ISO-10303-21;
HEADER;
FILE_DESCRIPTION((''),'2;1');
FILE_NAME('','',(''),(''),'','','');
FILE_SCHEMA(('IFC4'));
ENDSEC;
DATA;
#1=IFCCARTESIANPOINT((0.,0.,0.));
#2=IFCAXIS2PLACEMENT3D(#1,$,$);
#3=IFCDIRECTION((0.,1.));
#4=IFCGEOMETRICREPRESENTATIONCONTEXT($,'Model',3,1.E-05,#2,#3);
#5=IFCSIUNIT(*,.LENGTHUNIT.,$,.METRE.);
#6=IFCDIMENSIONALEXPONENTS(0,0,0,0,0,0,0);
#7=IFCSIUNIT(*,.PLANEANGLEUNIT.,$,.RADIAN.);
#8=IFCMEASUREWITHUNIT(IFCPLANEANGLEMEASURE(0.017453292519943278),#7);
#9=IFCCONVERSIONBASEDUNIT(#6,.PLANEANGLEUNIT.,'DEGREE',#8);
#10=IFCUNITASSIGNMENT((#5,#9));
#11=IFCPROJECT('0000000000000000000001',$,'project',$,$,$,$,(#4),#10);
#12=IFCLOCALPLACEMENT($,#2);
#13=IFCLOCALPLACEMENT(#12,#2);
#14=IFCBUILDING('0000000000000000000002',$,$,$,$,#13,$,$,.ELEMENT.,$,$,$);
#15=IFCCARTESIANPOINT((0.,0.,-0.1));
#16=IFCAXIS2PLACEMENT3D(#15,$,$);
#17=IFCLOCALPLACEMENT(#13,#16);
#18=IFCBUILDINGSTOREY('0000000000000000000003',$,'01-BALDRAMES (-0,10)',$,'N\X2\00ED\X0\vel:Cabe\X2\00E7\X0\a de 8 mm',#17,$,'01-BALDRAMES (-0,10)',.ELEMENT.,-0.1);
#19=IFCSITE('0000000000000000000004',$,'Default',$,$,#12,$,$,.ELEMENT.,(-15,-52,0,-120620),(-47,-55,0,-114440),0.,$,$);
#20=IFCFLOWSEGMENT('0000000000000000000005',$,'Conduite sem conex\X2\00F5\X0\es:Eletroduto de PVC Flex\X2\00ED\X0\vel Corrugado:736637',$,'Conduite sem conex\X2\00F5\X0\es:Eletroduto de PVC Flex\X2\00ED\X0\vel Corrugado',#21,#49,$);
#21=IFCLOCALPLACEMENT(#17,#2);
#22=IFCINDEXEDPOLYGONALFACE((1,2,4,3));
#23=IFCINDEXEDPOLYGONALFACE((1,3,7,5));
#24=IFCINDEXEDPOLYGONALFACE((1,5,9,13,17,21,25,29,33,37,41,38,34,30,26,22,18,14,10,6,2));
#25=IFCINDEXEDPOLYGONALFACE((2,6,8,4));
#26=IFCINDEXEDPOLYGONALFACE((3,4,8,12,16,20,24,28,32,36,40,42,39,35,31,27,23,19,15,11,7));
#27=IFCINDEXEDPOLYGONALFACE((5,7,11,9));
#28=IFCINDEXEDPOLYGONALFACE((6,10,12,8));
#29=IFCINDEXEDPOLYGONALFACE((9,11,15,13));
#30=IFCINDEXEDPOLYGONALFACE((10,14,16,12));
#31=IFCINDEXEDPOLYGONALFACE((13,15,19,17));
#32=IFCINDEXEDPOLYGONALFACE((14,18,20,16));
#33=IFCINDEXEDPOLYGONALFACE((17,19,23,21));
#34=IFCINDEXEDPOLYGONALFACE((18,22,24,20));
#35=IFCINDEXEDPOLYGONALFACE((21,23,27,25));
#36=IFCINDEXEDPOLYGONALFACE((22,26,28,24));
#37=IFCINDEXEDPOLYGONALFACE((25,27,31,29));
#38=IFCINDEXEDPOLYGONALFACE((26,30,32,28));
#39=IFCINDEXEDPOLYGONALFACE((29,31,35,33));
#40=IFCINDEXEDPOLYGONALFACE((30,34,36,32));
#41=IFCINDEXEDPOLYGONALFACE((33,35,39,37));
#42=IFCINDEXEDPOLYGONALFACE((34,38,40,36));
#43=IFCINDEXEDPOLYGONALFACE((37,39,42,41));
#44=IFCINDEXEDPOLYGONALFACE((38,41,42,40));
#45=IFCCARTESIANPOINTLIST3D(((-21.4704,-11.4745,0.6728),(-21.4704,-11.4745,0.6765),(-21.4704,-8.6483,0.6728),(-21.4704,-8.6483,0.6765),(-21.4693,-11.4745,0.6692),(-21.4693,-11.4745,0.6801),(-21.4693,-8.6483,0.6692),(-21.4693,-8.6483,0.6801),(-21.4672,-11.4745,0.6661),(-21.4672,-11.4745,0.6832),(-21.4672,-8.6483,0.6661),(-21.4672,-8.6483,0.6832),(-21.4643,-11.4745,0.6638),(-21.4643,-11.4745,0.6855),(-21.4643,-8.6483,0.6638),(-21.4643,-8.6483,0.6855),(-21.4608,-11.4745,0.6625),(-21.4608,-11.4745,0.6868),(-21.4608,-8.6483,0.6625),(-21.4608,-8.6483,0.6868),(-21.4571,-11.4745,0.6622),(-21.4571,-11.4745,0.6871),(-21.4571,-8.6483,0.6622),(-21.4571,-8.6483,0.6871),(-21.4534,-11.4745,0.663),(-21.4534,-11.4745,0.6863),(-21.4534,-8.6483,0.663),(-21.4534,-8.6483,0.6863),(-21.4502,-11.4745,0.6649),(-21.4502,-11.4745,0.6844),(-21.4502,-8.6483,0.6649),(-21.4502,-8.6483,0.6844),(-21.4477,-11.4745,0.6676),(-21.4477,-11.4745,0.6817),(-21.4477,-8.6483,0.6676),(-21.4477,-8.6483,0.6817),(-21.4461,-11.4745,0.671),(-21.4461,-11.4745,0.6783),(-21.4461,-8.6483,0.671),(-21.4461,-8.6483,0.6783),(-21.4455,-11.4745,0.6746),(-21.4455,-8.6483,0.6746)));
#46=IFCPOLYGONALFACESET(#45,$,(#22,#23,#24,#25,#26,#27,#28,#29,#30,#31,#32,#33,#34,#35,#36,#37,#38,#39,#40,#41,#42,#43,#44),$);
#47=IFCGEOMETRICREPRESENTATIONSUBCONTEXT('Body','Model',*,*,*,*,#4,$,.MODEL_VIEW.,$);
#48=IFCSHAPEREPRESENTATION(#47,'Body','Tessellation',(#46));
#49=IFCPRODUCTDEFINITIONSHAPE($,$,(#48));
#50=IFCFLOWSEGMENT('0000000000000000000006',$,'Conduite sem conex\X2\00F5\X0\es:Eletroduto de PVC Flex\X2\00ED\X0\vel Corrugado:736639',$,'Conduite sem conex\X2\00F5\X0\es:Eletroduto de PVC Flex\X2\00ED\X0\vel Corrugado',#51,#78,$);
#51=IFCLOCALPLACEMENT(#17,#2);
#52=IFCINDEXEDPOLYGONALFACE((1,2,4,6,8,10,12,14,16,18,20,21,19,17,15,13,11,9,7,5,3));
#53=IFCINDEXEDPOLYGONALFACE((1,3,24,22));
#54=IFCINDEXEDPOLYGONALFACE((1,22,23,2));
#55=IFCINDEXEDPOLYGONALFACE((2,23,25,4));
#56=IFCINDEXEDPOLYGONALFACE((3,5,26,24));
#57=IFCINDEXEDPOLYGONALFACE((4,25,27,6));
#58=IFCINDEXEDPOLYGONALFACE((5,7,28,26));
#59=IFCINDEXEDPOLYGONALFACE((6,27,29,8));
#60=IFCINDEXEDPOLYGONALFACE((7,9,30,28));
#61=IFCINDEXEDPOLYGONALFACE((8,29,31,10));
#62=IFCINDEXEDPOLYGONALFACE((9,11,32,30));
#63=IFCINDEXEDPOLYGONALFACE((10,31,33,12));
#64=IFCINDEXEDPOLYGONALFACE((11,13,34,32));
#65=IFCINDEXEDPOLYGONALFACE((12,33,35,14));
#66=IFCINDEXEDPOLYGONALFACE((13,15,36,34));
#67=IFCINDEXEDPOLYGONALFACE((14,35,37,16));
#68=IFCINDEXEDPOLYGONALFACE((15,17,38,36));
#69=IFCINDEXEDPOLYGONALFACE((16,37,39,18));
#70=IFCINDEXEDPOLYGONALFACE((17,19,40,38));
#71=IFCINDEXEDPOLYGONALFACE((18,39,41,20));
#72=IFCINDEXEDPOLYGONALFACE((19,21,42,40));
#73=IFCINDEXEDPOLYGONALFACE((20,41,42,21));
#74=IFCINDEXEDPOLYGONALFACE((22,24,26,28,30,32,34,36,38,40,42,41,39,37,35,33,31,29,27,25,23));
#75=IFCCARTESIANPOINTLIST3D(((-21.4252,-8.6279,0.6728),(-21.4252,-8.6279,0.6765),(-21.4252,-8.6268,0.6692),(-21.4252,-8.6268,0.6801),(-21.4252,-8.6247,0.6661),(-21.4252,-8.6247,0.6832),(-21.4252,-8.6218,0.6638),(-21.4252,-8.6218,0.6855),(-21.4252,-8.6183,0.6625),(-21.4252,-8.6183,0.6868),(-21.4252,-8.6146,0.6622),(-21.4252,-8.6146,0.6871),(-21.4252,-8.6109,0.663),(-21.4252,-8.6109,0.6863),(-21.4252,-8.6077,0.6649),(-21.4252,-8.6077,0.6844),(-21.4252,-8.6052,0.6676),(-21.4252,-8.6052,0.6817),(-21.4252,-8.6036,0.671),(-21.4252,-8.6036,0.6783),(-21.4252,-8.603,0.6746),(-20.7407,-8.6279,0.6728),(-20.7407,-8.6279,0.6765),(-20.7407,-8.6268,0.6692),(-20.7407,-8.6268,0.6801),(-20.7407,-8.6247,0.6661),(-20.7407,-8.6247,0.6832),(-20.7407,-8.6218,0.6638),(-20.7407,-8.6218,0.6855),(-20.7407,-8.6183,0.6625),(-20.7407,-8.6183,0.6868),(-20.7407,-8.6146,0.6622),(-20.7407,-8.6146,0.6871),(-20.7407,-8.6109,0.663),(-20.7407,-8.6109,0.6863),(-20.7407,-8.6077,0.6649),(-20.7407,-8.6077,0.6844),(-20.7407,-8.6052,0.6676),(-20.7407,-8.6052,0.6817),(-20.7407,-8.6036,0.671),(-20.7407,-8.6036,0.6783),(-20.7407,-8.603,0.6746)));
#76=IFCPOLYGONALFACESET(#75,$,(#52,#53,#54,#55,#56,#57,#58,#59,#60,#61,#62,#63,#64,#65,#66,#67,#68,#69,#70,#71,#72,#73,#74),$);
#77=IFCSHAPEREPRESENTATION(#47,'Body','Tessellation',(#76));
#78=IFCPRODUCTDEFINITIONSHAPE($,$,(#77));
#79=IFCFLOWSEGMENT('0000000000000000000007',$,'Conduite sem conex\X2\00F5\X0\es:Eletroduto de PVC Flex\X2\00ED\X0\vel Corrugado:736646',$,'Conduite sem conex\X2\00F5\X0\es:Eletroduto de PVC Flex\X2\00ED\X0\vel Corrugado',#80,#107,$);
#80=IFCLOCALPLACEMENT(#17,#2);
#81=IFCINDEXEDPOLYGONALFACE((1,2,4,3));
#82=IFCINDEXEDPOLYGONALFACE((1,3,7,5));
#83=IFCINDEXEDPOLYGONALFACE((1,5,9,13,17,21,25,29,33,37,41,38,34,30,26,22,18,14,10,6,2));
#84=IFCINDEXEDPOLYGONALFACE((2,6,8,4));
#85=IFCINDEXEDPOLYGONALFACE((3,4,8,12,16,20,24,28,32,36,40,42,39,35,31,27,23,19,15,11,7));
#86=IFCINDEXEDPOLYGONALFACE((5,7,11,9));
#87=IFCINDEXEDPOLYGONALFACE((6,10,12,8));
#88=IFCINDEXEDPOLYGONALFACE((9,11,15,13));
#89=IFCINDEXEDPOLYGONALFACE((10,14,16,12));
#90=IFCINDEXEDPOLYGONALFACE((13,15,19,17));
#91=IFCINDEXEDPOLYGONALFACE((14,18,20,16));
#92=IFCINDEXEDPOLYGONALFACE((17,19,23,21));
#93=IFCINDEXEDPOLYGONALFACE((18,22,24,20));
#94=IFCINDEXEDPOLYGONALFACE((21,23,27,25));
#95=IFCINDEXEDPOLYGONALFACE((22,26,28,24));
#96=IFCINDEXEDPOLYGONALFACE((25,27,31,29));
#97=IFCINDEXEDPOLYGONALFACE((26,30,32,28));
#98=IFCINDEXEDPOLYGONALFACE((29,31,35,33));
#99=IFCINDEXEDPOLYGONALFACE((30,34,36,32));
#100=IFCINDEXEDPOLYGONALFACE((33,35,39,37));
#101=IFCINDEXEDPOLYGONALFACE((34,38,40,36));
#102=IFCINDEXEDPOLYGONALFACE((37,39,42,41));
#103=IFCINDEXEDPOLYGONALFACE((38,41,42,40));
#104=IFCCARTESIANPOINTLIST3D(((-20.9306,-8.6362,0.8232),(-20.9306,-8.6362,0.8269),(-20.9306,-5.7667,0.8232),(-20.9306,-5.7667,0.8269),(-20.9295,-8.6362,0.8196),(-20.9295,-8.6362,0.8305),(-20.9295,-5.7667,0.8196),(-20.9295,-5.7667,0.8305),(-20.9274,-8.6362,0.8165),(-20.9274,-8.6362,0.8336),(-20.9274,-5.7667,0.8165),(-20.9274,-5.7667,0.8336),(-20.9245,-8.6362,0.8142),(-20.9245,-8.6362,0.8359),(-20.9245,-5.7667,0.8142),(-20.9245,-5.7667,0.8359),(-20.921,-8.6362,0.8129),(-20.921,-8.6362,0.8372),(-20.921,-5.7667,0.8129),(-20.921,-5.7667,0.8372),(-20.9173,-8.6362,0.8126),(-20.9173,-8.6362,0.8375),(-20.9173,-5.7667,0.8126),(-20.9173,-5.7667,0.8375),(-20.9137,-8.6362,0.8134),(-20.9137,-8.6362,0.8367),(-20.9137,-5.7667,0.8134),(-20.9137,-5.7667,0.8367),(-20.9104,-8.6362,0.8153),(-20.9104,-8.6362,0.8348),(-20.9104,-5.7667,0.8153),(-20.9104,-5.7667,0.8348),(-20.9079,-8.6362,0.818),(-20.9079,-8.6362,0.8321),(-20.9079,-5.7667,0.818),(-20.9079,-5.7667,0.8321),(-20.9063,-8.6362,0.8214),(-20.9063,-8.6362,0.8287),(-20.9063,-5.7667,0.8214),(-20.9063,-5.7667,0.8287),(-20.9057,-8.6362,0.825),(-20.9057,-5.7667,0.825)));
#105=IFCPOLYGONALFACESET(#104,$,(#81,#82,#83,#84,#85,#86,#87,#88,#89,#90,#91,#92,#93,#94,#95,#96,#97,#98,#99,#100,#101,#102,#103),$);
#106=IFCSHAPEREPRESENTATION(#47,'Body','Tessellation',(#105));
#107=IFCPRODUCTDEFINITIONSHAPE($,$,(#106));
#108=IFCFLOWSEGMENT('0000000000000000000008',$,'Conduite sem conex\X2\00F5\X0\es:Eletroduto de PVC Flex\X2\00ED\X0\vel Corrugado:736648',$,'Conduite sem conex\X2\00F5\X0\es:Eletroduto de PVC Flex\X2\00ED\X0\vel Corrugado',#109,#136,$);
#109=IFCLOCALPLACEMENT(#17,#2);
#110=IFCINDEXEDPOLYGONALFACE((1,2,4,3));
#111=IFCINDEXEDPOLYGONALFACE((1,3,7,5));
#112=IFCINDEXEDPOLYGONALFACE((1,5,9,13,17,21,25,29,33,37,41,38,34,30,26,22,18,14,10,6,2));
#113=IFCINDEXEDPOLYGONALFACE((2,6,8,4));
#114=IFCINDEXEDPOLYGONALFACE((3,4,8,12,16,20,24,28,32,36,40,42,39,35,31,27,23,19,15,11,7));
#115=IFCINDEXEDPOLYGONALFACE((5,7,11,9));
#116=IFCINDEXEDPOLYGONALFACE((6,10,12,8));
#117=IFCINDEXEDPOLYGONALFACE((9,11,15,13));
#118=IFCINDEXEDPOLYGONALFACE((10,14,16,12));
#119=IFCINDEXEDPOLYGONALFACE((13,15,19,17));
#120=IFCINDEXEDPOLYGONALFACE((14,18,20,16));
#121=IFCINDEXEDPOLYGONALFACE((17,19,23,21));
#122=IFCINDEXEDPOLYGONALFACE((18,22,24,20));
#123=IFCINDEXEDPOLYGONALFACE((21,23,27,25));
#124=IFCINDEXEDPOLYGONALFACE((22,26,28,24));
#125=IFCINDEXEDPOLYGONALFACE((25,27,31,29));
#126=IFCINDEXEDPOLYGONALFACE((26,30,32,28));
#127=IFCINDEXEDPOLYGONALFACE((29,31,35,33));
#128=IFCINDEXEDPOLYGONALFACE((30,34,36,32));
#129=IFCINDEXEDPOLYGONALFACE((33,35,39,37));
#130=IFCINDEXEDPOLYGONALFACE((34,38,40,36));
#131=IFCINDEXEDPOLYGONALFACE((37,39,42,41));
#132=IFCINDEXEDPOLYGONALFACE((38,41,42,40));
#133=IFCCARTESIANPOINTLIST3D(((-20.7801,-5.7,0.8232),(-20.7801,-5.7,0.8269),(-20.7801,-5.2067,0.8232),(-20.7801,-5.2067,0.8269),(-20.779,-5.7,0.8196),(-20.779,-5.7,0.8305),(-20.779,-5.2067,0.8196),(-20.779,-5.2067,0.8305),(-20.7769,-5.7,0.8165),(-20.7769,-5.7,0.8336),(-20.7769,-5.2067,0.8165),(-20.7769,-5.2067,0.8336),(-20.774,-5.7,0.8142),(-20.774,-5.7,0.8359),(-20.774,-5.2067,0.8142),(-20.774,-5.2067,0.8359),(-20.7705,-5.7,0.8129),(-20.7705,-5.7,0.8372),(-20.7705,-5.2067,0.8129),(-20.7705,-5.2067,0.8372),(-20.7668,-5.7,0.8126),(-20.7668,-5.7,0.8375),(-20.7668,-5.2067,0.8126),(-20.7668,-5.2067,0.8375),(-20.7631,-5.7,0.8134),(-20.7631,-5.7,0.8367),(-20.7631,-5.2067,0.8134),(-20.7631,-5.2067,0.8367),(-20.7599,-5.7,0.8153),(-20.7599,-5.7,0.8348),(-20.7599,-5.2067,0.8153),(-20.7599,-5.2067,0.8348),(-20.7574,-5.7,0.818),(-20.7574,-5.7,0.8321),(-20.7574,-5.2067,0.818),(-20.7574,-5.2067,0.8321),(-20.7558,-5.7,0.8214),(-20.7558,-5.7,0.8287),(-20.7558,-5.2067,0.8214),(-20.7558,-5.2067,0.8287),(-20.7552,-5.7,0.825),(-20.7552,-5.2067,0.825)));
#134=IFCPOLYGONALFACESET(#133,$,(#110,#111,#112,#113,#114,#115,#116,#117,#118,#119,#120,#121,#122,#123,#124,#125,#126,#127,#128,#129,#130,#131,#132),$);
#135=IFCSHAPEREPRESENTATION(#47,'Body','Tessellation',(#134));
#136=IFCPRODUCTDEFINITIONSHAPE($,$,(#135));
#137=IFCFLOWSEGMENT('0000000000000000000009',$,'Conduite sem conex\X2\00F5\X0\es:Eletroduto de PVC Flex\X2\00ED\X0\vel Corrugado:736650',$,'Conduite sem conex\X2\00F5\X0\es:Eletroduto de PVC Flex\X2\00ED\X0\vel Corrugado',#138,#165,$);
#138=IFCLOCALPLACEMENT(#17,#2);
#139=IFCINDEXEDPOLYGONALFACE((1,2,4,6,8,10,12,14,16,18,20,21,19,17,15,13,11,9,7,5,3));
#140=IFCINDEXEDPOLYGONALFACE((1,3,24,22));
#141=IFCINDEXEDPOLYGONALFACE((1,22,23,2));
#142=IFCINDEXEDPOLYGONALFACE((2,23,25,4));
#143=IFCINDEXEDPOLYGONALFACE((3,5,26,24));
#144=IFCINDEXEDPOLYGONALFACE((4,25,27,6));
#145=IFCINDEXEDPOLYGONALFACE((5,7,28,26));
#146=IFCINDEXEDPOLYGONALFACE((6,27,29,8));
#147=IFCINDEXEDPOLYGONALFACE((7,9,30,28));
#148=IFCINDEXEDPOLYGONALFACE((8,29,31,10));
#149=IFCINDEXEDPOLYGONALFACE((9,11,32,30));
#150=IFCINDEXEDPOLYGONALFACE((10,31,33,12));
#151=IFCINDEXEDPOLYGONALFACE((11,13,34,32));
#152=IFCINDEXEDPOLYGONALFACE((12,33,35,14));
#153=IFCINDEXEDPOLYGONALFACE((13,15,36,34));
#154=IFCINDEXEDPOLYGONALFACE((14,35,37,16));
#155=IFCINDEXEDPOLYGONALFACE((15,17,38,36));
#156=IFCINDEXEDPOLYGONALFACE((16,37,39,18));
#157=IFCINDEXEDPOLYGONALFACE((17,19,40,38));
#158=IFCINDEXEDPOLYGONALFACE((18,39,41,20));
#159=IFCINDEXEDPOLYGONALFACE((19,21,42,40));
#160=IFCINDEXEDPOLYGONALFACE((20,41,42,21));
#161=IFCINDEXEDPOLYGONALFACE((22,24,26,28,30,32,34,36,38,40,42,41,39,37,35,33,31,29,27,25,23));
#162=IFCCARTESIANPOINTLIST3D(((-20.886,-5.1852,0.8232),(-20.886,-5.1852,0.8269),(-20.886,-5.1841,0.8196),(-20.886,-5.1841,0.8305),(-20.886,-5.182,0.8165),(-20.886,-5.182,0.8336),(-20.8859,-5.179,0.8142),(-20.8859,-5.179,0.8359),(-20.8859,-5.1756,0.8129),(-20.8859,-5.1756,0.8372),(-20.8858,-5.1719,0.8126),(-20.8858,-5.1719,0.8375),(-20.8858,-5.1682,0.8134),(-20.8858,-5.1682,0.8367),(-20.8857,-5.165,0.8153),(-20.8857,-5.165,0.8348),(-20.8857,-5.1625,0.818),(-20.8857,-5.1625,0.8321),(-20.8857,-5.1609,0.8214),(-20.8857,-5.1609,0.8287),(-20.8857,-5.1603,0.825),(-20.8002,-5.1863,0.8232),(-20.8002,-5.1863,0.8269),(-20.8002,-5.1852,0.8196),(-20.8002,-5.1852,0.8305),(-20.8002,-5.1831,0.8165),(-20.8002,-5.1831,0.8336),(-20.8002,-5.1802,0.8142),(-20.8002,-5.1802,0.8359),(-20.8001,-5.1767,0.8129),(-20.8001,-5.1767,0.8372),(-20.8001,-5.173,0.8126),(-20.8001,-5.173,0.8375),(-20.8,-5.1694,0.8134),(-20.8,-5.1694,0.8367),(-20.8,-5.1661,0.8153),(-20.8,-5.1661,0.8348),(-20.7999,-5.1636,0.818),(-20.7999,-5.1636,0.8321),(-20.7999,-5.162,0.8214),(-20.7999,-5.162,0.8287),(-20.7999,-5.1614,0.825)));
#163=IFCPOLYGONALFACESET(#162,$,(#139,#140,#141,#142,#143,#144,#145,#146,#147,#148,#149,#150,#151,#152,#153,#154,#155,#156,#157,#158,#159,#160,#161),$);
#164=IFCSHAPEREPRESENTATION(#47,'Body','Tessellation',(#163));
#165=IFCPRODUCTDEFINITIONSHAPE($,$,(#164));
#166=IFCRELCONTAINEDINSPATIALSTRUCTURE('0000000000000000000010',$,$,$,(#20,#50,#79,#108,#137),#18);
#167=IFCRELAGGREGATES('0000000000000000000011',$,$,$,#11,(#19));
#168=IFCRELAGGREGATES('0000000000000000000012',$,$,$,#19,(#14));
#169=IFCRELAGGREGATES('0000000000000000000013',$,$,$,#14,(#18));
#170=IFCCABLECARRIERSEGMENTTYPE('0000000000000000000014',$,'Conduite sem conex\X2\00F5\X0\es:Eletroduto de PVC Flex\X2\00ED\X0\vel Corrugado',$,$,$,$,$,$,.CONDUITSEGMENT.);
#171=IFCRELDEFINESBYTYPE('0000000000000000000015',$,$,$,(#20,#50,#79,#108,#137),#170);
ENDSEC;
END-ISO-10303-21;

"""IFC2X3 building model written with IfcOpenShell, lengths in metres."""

from ifc_helpers import new_model, entity, si_unit, converted_unit, direction, frame, frame_2d, origin, origin_2d_with_axis, place, context, subcontext, project, spatial, circle, extrude, type_object, element, save


model = new_model("IFC2X3")

# Units and contexts
model_context = context("Model", 3, precision=1e-05, world=origin(), true_north=direction((0.0, 1.0)))
body_context = subcontext(model_context, "Body", "Model", "MODEL_VIEW")
ifc_project = project(units=[si_unit("LENGTHUNIT", "METRE"), converted_unit("PLANEANGLEUNIT", "DEGREE", entity("IfcPlaneAngleMeasure", 0.017453292519943278), si_unit("PLANEANGLEUNIT", "RADIAN"), dimensions=[0, 0, 0, 0, 0, 0, 0])], contexts=[model_context])

# Site, building, storey
site_placement = place(None, origin())
site = spatial("IfcSite", under=ifc_project, at=site_placement, Name="Default", CompositionType="ELEMENT", RefLatitude=(-15, -52, 0, -120620), RefLongitude=(-47, -55, 0, -114440), RefElevation=0.0)
building_placement = place(site_placement, origin())
building = spatial("IfcBuilding", under=site, at=building_placement, CompositionType="ELEMENT")
storey_placement = place(building_placement, frame((0.0, 0.0, -0.1)))
storey = spatial("IfcBuildingStorey", under=building, at=storey_placement, Name="01-BALDRAMES (-0,10)", ObjectType="Nível:Cabeça de 8 mm", LongName="01-BALDRAMES (-0,10)", CompositionType="ELEMENT", Elevation=-0.1)

# Flow segments
cable_carrier_segment_type = type_object("IfcCableCarrierSegmentType", Name="Conduite sem conexões:Eletroduto de PVC Flexível Corrugado", PredefinedType="CONDUITSEGMENT")
flow_segment_1_placement = place(storey_placement, origin())
element("IfcFlowSegment", 1, at=flow_segment_1_placement, inside=storey, type_object=cable_carrier_segment_type, Name="Conduite sem conexões:Eletroduto de PVC Flexível Corrugado:736637", ObjectType="Conduite sem conexões:Eletroduto de PVC Flexível Corrugado", context=body_context, shape_type="SweptSolid", body=[
    extrude(circle(Radius=0.0125, at=origin_2d_with_axis()), frame((-21.458, -11.4745, 0.6746), z_axis=(0.0, 1.0, 0.0), x_axis=(1.0, 0.0, 0.0)), (0.0, 0.0, 1.0), 2.8262),
])
flow_segment_2_placement = place(storey_placement, origin())
element("IfcFlowSegment", 2, at=flow_segment_2_placement, inside=storey, type_object=cable_carrier_segment_type, Name="Conduite sem conexões:Eletroduto de PVC Flexível Corrugado:736639", ObjectType="Conduite sem conexões:Eletroduto de PVC Flexível Corrugado", context=body_context, shape_type="SweptSolid", body=[
    extrude(circle(Radius=0.0125, at=frame_2d((0.0, 0.0), x_axis=(1.0, 0.0))), frame((-21.4252, -8.6155, 0.6746), z_axis=(1.0, 0.0, 0.0), x_axis=(0.0, 1.0, 0.0)), (0.0, 0.0, 1.0), 0.6845),
])
flow_segment_3_placement = place(storey_placement, origin())
element("IfcFlowSegment", 3, at=flow_segment_3_placement, inside=storey, type_object=cable_carrier_segment_type, Name="Conduite sem conexões:Eletroduto de PVC Flexível Corrugado:736646", ObjectType="Conduite sem conexões:Eletroduto de PVC Flexível Corrugado", context=body_context, shape_type="SweptSolid", body=[
    extrude(circle(Radius=0.0125, at=frame_2d((0.0, 0.0), x_axis=(1.0, 0.0))), frame((-20.9182, -8.6362, 0.825), z_axis=(0.0, 1.0, 0.0), x_axis=(1.0, 0.0, 0.0)), (0.0, 0.0, 1.0), 2.8694),
])
flow_segment_4_placement = place(storey_placement, origin())
element("IfcFlowSegment", 4, at=flow_segment_4_placement, inside=storey, type_object=cable_carrier_segment_type, Name="Conduite sem conexões:Eletroduto de PVC Flexível Corrugado:736648", ObjectType="Conduite sem conexões:Eletroduto de PVC Flexível Corrugado", context=body_context, shape_type="SweptSolid", body=[
    extrude(circle(Radius=0.0125, at=frame_2d((0.0, 0.0), x_axis=(1.0, 0.0))), frame((-20.7677, -5.7, 0.825), z_axis=(0.0, 1.0, 0.0), x_axis=(1.0, 0.0, 0.0)), (0.0, 0.0, 1.0), 0.4932),
])
flow_segment_5_placement = place(storey_placement, origin())
element("IfcFlowSegment", 5, at=flow_segment_5_placement, inside=storey, type_object=cable_carrier_segment_type, Name="Conduite sem conexões:Eletroduto de PVC Flexível Corrugado:736650", ObjectType="Conduite sem conexões:Eletroduto de PVC Flexível Corrugado", context=body_context, shape_type="SweptSolid", body=[
    extrude(circle(Radius=0.0125, at=origin_2d_with_axis()), frame((-20.8859, -5.1728, 0.825), z_axis=(0.999912, -0.013286, 0.0), x_axis=(0.013286, 0.999912, 0.0)), (0.0, 0.0, 1.0), 0.0858),
])

save(model, "model.ifc")
